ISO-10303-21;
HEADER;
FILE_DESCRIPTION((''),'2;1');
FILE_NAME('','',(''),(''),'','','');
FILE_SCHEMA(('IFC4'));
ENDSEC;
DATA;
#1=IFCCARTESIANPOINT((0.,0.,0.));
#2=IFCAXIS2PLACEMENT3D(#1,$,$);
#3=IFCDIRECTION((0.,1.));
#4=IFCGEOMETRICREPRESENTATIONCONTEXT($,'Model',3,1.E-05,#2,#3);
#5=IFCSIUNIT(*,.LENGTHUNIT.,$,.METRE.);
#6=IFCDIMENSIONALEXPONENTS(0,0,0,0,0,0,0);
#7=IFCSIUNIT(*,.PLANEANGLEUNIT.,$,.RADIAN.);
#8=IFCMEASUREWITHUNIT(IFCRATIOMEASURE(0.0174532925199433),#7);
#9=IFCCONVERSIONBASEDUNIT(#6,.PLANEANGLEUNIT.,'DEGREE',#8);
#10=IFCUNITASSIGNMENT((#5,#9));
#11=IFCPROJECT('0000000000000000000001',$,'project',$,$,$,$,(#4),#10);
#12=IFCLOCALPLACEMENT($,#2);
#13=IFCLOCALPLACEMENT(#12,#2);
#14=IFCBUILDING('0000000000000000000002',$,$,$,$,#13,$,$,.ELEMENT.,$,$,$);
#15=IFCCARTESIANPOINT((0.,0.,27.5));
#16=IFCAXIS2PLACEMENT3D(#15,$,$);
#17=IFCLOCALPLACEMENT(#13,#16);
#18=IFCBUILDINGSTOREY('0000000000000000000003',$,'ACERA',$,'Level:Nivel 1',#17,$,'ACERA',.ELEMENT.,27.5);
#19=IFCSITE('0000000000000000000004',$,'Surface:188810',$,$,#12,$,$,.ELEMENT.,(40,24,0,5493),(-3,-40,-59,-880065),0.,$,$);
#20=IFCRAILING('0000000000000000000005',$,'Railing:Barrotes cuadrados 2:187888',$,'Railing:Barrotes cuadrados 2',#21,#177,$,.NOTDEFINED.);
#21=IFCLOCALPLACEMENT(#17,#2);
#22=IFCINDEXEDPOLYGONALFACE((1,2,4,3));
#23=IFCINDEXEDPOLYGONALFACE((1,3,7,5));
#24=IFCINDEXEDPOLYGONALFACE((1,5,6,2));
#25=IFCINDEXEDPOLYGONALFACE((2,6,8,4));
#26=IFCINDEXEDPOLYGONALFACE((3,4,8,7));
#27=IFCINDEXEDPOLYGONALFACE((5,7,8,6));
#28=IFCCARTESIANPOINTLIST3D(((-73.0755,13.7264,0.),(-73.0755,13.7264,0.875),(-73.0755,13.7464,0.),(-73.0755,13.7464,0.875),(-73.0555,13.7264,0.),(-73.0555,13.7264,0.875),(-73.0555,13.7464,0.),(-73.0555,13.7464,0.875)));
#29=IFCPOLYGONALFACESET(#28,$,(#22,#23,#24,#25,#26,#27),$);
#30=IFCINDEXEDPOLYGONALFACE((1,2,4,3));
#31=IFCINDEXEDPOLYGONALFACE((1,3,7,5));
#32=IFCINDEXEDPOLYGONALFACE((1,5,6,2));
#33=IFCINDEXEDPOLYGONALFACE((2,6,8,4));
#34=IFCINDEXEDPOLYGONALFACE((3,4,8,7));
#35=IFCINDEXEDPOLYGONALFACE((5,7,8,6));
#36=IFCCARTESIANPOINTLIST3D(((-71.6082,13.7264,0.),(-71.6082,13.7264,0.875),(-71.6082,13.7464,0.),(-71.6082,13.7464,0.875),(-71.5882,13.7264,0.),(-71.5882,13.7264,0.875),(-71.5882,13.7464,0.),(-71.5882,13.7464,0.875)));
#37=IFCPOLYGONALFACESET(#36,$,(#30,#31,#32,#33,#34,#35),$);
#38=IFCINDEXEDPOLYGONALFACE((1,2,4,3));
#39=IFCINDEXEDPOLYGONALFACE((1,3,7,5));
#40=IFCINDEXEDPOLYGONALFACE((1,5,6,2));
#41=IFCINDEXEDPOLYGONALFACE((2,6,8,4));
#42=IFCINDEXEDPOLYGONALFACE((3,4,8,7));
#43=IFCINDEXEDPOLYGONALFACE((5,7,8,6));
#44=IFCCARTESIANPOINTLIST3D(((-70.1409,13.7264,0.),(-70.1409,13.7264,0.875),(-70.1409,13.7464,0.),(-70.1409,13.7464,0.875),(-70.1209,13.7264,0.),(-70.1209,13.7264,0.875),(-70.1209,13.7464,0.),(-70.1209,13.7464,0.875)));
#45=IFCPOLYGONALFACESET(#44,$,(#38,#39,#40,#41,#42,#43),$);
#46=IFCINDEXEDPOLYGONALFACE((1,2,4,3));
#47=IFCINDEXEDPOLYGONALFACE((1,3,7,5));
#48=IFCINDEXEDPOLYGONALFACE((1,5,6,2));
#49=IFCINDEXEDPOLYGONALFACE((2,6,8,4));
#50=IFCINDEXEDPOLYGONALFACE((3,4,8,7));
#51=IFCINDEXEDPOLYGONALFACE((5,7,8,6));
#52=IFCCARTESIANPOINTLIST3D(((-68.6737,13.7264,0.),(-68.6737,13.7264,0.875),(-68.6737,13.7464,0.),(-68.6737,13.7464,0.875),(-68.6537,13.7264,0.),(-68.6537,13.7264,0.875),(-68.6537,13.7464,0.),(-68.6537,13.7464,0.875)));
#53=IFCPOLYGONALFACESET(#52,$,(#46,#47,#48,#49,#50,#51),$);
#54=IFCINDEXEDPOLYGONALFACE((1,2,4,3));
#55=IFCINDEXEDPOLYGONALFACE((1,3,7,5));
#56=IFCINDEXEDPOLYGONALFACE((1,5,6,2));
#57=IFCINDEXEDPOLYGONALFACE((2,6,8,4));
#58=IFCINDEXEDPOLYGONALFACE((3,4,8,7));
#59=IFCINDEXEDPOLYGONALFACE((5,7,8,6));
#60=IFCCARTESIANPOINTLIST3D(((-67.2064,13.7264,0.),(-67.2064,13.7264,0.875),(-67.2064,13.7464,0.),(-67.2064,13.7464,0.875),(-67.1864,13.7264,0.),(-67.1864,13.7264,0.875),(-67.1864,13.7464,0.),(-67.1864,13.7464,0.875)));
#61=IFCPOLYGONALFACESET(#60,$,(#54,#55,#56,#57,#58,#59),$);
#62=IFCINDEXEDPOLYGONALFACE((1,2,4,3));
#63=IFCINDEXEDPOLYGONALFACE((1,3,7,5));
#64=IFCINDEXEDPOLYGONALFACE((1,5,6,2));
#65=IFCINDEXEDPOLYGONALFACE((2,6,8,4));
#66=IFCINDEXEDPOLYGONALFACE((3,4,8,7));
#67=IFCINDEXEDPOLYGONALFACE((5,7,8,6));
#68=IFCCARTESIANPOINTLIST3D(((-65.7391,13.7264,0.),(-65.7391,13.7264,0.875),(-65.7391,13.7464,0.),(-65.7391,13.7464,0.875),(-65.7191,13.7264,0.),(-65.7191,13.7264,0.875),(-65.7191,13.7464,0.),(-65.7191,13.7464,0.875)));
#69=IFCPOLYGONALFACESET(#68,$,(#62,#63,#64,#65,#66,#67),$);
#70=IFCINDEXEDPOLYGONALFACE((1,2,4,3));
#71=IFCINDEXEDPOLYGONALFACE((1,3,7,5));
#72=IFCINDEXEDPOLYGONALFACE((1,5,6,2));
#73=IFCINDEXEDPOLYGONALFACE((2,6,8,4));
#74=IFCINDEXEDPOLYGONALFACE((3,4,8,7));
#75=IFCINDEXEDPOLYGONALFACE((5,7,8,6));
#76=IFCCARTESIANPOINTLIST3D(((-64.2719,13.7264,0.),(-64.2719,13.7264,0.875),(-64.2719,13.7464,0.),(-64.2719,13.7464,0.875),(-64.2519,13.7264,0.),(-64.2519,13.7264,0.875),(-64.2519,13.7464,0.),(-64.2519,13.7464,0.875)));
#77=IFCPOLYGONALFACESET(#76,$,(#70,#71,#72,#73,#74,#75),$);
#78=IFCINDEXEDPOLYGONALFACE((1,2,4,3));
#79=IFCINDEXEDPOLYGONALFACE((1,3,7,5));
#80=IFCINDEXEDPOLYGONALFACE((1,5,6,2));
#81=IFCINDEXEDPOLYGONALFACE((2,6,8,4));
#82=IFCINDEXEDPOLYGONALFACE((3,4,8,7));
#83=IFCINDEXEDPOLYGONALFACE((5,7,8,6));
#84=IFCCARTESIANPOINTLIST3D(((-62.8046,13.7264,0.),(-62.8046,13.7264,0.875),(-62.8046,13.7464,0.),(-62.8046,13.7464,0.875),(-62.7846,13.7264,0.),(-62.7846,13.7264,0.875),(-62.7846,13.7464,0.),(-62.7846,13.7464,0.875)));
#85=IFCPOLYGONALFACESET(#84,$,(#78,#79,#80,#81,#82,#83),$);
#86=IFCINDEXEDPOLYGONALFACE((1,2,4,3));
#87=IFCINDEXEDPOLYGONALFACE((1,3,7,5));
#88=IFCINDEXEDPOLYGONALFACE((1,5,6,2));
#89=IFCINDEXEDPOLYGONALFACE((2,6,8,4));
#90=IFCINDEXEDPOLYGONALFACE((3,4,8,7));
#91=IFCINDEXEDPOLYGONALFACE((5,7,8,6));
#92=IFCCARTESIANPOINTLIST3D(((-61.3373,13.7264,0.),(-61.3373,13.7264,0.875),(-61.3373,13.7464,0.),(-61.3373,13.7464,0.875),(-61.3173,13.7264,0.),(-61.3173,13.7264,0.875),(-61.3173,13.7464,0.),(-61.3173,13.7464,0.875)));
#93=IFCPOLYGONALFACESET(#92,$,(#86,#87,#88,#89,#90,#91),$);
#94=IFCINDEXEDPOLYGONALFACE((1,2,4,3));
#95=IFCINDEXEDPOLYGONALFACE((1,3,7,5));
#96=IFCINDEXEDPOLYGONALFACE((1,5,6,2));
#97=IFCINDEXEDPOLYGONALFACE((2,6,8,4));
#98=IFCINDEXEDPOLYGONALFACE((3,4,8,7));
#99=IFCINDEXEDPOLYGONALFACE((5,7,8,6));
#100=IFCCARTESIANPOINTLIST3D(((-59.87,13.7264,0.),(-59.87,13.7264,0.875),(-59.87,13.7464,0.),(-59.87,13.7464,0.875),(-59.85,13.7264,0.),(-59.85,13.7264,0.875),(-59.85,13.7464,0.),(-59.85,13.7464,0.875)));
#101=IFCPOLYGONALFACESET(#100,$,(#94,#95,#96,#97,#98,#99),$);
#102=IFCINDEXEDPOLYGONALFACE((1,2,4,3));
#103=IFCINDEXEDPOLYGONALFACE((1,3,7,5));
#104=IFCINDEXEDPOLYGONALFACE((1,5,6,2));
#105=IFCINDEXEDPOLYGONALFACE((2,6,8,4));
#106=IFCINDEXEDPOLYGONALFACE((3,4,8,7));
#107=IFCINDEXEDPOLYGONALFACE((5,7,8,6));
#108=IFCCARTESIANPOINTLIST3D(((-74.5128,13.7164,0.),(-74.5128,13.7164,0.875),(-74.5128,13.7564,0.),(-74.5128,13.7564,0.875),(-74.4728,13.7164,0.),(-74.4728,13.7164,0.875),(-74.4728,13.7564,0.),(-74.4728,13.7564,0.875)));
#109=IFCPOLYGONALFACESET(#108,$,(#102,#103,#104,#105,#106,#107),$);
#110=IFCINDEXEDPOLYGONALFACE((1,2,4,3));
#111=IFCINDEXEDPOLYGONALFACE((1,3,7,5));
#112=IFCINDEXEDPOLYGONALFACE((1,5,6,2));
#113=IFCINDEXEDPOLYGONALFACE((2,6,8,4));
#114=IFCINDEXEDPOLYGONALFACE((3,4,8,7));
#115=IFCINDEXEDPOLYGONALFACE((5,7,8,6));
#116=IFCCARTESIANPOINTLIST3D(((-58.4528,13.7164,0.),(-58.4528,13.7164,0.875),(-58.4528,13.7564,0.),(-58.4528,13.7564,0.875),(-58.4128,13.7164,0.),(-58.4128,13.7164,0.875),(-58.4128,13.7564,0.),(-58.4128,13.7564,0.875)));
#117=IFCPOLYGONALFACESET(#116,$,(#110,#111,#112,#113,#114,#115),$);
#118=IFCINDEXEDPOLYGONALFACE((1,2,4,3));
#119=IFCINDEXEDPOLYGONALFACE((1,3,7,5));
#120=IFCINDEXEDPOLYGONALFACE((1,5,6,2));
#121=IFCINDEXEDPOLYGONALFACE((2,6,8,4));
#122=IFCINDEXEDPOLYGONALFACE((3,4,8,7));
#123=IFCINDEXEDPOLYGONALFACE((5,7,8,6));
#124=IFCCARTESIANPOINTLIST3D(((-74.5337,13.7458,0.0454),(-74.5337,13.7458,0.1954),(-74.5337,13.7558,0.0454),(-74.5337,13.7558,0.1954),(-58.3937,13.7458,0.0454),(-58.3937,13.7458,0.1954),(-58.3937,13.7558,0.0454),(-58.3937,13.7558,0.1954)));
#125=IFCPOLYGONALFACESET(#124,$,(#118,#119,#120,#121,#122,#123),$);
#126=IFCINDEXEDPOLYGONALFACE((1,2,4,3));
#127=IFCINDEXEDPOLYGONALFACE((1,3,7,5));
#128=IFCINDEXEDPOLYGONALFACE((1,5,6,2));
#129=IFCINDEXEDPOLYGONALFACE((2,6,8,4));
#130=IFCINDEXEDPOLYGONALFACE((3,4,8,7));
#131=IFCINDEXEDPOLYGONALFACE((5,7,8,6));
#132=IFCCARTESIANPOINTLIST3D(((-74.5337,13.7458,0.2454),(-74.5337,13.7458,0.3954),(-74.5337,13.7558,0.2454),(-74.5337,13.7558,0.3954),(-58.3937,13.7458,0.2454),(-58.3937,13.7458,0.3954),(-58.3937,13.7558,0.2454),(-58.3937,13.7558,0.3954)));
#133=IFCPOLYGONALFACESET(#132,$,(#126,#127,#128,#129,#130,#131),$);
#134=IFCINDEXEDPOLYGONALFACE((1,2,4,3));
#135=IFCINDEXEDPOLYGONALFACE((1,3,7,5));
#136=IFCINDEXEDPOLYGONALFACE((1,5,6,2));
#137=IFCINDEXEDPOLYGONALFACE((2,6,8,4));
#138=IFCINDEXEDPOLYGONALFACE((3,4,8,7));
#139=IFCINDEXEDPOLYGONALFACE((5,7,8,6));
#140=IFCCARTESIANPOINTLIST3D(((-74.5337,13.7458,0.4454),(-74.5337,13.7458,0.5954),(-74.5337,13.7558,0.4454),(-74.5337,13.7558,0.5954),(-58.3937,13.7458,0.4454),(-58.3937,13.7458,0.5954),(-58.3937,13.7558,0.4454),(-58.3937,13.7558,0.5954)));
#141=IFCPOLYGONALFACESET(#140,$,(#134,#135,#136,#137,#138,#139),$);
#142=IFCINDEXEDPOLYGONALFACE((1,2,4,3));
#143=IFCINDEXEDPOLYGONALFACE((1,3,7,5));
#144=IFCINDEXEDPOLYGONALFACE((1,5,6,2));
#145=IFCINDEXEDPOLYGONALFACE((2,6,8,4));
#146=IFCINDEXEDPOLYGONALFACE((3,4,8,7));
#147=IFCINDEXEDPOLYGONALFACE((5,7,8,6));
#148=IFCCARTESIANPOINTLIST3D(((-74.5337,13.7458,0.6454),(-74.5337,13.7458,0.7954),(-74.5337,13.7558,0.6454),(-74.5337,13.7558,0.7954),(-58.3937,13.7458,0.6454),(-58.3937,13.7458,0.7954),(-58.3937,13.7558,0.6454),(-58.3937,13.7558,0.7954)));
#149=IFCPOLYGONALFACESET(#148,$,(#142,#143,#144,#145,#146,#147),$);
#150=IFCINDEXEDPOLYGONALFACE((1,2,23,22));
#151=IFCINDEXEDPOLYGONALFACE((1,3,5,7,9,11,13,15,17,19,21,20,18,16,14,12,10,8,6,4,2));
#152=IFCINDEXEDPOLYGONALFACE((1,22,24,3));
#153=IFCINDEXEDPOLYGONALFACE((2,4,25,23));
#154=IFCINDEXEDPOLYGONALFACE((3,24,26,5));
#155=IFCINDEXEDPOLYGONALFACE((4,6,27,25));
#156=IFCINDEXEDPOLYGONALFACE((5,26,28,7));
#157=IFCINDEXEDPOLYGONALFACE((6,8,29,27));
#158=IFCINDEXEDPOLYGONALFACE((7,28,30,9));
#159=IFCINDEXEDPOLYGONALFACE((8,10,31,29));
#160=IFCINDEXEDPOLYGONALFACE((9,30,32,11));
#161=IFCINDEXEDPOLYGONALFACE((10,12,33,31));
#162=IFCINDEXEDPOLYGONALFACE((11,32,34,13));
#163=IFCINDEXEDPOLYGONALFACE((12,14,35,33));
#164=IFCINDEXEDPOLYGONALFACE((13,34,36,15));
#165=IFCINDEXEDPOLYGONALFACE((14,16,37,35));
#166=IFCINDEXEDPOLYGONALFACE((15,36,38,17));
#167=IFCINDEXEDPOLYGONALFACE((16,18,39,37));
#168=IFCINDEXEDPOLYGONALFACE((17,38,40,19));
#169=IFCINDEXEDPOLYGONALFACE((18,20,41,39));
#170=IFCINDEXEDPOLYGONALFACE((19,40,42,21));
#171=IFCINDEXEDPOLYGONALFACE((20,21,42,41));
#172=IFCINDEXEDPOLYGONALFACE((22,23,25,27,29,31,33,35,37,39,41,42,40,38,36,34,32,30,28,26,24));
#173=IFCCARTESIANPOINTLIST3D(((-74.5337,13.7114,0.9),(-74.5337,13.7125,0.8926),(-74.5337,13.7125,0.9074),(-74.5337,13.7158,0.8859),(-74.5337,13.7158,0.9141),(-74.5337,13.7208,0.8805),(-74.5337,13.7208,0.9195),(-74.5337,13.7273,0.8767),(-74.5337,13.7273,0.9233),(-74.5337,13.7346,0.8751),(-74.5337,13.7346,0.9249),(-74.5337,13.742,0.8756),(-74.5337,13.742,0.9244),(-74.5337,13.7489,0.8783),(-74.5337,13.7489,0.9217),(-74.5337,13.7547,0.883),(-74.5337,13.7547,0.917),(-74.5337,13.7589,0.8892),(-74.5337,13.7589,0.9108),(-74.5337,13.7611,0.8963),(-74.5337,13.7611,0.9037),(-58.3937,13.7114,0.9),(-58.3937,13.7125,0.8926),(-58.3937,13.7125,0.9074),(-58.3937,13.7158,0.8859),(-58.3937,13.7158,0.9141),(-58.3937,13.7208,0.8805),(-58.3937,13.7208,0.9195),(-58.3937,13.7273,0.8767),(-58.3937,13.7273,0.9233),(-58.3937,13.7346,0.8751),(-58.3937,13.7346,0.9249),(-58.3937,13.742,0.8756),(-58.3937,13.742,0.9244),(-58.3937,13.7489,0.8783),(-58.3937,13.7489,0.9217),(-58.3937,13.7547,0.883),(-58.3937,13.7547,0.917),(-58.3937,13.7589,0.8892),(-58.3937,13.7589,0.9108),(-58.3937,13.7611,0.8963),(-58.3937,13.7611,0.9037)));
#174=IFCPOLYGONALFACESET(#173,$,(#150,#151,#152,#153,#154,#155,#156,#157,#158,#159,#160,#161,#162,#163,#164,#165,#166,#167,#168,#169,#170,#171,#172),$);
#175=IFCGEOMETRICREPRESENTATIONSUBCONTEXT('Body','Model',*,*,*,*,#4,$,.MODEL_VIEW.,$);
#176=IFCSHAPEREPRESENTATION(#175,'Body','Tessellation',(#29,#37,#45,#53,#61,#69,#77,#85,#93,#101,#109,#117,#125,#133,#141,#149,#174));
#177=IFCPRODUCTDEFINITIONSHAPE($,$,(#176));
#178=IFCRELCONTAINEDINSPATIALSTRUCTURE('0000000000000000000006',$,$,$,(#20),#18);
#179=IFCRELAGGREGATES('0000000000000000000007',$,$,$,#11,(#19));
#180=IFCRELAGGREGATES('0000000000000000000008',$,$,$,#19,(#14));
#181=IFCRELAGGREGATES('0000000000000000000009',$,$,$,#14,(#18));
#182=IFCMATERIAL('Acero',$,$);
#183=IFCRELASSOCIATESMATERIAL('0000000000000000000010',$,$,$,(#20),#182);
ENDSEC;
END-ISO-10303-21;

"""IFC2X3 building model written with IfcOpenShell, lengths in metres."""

from ifc_helpers import new_model, entity, si_unit, converted_unit, direction, frame, frame_2d, origin, origin_2d_with_axis, place, context, subcontext, project, spatial, rectangle, circle, extrude, material, element, save


model = new_model("IFC2X3")

# Units and contexts
model_context = context("Model", 3, precision=1e-05, world=origin(), true_north=direction((0.0, 1.0)))
body_context = subcontext(model_context, "Body", "Model", "MODEL_VIEW")
ifc_project = project(units=[si_unit("LENGTHUNIT", "METRE"), converted_unit("PLANEANGLEUNIT", "DEGREE", entity("IfcRatioMeasure", 0.0174532925199433), si_unit("PLANEANGLEUNIT", "RADIAN"), dimensions=[0, 0, 0, 0, 0, 0, 0])], contexts=[model_context])

# Site, building, storey
site_placement = place(None, origin())
site = spatial("IfcSite", under=ifc_project, at=site_placement, Name="Surface:188810", CompositionType="ELEMENT", RefLatitude=(40, 24, 0, 5493), RefLongitude=(-3, -40, -59, -880065), RefElevation=0.0)
building_placement = place(site_placement, origin())
building = spatial("IfcBuilding", under=site, at=building_placement, CompositionType="ELEMENT")
storey_placement = place(building_placement, frame((0.0, 0.0, 27.5)))
storey = spatial("IfcBuildingStorey", under=building, at=storey_placement, Name="ACERA", ObjectType="Level:Nivel 1", LongName="ACERA", CompositionType="ELEMENT", Elevation=27.5)

# Railing
ifc_material_1 = material(Name="Acero")
railing_1_placement = place(storey_placement, origin())
element("IfcRailing", 1, at=railing_1_placement, inside=storey, material=ifc_material_1, Name="Railing:Barrotes cuadrados 2:187888", ObjectType="Railing:Barrotes cuadrados 2", PredefinedType="NOTDEFINED", context=body_context, shape_type="SweptSolid", body=[
    extrude(rectangle(XDim=0.02, YDim=0.02, at=frame_2d((0.0, 0.0), x_axis=(1.0, 0.0))), frame((-73.0655, 13.7364, 0.0), z_axis=(0.0, 0.0, 1.0), x_axis=(0.0, 1.0, 0.0)), (0.0, 0.0, 1.0), 0.875),
    extrude(rectangle(XDim=0.02, YDim=0.02, at=frame_2d((0.0, 0.0), x_axis=(1.0, 0.0))), frame((-71.5982, 13.7364, 0.0), z_axis=(0.0, 0.0, 1.0), x_axis=(0.0, 1.0, 0.0)), (0.0, 0.0, 1.0), 0.875),
    extrude(rectangle(XDim=0.02, YDim=0.02, at=frame_2d((0.0, 0.0), x_axis=(1.0, 0.0))), frame((-70.1309, 13.7364, 0.0), z_axis=(0.0, 0.0, 1.0), x_axis=(0.0, 1.0, 0.0)), (0.0, 0.0, 1.0), 0.875),
    extrude(rectangle(XDim=0.02, YDim=0.02, at=frame_2d((0.0, 0.0), x_axis=(1.0, 0.0))), frame((-68.6637, 13.7364, 0.0), z_axis=(0.0, 0.0, 1.0), x_axis=(0.0, 1.0, 0.0)), (0.0, 0.0, 1.0), 0.875),
    extrude(rectangle(XDim=0.02, YDim=0.02, at=frame_2d((0.0, 0.0), x_axis=(1.0, 0.0))), frame((-67.1964, 13.7364, 0.0), z_axis=(0.0, 0.0, 1.0), x_axis=(0.0, 1.0, 0.0)), (0.0, 0.0, 1.0), 0.875),
    extrude(rectangle(XDim=0.02, YDim=0.02, at=frame_2d((0.0, 0.0), x_axis=(1.0, 0.0))), frame((-65.7291, 13.7364, 0.0), z_axis=(0.0, 0.0, 1.0), x_axis=(0.0, 1.0, 0.0)), (0.0, 0.0, 1.0), 0.875),
    extrude(rectangle(XDim=0.02, YDim=0.02, at=frame_2d((0.0, 0.0), x_axis=(1.0, 0.0))), frame((-64.2619, 13.7364, 0.0), z_axis=(0.0, 0.0, 1.0), x_axis=(0.0, 1.0, 0.0)), (0.0, 0.0, 1.0), 0.875),
    extrude(rectangle(XDim=0.02, YDim=0.02, at=frame_2d((0.0, 0.0), x_axis=(1.0, 0.0))), frame((-62.7946, 13.7364, 0.0), z_axis=(0.0, 0.0, 1.0), x_axis=(0.0, 1.0, 0.0)), (0.0, 0.0, 1.0), 0.875),
    extrude(rectangle(XDim=0.02, YDim=0.02, at=frame_2d((0.0, 0.0), x_axis=(1.0, 0.0))), frame((-61.3273, 13.7364, 0.0), z_axis=(0.0, 0.0, 1.0), x_axis=(0.0, 1.0, 0.0)), (0.0, 0.0, 1.0), 0.875),
    extrude(rectangle(XDim=0.02, YDim=0.02, at=frame_2d((0.0, 0.0), x_axis=(1.0, 0.0))), frame((-59.86, 13.7364, 0.0), z_axis=(0.0, 0.0, 1.0), x_axis=(0.0, 1.0, 0.0)), (0.0, 0.0, 1.0), 0.875),
    extrude(rectangle(XDim=0.04, YDim=0.04, at=frame_2d((0.0, 0.0), x_axis=(1.0, 0.0))), frame((-74.4928, 13.7364, 0.0), z_axis=(0.0, 0.0, 1.0), x_axis=(0.0, 1.0, 0.0)), (0.0, 0.0, 1.0), 0.875),
    extrude(rectangle(XDim=0.04, YDim=0.04, at=frame_2d((0.0, 0.0), x_axis=(1.0, 0.0))), frame((-58.4328, 13.7364, 0.0), z_axis=(0.0, 0.0, 1.0), x_axis=(0.0, 1.0, 0.0)), (0.0, 0.0, 1.0), 0.875),
    extrude(rectangle(XDim=16.14, YDim=0.01, at=frame_2d((0.0, 0.0), x_axis=(1.0, 0.0))), frame((-66.4637, 13.7508, 0.0454), z_axis=(0.0, 0.0, 1.0), x_axis=(-1.0, 0.0, 0.0)), (0.0, 0.0, 1.0), 0.15),
    extrude(rectangle(XDim=16.14, YDim=0.01, at=frame_2d((0.0, 0.0), x_axis=(1.0, 0.0))), frame((-66.4637, 13.7508, 0.2454), z_axis=(0.0, 0.0, 1.0), x_axis=(-1.0, 0.0, 0.0)), (0.0, 0.0, 1.0), 0.15),
    extrude(rectangle(XDim=16.14, YDim=0.01, at=frame_2d((0.0, 0.0), x_axis=(1.0, 0.0))), frame((-66.4637, 13.7508, 0.4454), z_axis=(0.0, 0.0, 1.0), x_axis=(-1.0, 0.0, 0.0)), (0.0, 0.0, 1.0), 0.15),
    extrude(rectangle(XDim=16.14, YDim=0.01, at=frame_2d((0.0, 0.0), x_axis=(1.0, 0.0))), frame((-66.4637, 13.7508, 0.6454), z_axis=(0.0, 0.0, 1.0), x_axis=(-1.0, 0.0, 0.0)), (0.0, 0.0, 1.0), 0.15),
    extrude(circle(Radius=0.025, at=origin_2d_with_axis()), frame((-74.5337, 13.7364, 0.9), z_axis=(1.0, 0.0, 0.0), x_axis=(0.0, -1.0, 0.0)), (0.0, 0.0, 1.0), 16.14),
])

save(model, "model.ifc")
